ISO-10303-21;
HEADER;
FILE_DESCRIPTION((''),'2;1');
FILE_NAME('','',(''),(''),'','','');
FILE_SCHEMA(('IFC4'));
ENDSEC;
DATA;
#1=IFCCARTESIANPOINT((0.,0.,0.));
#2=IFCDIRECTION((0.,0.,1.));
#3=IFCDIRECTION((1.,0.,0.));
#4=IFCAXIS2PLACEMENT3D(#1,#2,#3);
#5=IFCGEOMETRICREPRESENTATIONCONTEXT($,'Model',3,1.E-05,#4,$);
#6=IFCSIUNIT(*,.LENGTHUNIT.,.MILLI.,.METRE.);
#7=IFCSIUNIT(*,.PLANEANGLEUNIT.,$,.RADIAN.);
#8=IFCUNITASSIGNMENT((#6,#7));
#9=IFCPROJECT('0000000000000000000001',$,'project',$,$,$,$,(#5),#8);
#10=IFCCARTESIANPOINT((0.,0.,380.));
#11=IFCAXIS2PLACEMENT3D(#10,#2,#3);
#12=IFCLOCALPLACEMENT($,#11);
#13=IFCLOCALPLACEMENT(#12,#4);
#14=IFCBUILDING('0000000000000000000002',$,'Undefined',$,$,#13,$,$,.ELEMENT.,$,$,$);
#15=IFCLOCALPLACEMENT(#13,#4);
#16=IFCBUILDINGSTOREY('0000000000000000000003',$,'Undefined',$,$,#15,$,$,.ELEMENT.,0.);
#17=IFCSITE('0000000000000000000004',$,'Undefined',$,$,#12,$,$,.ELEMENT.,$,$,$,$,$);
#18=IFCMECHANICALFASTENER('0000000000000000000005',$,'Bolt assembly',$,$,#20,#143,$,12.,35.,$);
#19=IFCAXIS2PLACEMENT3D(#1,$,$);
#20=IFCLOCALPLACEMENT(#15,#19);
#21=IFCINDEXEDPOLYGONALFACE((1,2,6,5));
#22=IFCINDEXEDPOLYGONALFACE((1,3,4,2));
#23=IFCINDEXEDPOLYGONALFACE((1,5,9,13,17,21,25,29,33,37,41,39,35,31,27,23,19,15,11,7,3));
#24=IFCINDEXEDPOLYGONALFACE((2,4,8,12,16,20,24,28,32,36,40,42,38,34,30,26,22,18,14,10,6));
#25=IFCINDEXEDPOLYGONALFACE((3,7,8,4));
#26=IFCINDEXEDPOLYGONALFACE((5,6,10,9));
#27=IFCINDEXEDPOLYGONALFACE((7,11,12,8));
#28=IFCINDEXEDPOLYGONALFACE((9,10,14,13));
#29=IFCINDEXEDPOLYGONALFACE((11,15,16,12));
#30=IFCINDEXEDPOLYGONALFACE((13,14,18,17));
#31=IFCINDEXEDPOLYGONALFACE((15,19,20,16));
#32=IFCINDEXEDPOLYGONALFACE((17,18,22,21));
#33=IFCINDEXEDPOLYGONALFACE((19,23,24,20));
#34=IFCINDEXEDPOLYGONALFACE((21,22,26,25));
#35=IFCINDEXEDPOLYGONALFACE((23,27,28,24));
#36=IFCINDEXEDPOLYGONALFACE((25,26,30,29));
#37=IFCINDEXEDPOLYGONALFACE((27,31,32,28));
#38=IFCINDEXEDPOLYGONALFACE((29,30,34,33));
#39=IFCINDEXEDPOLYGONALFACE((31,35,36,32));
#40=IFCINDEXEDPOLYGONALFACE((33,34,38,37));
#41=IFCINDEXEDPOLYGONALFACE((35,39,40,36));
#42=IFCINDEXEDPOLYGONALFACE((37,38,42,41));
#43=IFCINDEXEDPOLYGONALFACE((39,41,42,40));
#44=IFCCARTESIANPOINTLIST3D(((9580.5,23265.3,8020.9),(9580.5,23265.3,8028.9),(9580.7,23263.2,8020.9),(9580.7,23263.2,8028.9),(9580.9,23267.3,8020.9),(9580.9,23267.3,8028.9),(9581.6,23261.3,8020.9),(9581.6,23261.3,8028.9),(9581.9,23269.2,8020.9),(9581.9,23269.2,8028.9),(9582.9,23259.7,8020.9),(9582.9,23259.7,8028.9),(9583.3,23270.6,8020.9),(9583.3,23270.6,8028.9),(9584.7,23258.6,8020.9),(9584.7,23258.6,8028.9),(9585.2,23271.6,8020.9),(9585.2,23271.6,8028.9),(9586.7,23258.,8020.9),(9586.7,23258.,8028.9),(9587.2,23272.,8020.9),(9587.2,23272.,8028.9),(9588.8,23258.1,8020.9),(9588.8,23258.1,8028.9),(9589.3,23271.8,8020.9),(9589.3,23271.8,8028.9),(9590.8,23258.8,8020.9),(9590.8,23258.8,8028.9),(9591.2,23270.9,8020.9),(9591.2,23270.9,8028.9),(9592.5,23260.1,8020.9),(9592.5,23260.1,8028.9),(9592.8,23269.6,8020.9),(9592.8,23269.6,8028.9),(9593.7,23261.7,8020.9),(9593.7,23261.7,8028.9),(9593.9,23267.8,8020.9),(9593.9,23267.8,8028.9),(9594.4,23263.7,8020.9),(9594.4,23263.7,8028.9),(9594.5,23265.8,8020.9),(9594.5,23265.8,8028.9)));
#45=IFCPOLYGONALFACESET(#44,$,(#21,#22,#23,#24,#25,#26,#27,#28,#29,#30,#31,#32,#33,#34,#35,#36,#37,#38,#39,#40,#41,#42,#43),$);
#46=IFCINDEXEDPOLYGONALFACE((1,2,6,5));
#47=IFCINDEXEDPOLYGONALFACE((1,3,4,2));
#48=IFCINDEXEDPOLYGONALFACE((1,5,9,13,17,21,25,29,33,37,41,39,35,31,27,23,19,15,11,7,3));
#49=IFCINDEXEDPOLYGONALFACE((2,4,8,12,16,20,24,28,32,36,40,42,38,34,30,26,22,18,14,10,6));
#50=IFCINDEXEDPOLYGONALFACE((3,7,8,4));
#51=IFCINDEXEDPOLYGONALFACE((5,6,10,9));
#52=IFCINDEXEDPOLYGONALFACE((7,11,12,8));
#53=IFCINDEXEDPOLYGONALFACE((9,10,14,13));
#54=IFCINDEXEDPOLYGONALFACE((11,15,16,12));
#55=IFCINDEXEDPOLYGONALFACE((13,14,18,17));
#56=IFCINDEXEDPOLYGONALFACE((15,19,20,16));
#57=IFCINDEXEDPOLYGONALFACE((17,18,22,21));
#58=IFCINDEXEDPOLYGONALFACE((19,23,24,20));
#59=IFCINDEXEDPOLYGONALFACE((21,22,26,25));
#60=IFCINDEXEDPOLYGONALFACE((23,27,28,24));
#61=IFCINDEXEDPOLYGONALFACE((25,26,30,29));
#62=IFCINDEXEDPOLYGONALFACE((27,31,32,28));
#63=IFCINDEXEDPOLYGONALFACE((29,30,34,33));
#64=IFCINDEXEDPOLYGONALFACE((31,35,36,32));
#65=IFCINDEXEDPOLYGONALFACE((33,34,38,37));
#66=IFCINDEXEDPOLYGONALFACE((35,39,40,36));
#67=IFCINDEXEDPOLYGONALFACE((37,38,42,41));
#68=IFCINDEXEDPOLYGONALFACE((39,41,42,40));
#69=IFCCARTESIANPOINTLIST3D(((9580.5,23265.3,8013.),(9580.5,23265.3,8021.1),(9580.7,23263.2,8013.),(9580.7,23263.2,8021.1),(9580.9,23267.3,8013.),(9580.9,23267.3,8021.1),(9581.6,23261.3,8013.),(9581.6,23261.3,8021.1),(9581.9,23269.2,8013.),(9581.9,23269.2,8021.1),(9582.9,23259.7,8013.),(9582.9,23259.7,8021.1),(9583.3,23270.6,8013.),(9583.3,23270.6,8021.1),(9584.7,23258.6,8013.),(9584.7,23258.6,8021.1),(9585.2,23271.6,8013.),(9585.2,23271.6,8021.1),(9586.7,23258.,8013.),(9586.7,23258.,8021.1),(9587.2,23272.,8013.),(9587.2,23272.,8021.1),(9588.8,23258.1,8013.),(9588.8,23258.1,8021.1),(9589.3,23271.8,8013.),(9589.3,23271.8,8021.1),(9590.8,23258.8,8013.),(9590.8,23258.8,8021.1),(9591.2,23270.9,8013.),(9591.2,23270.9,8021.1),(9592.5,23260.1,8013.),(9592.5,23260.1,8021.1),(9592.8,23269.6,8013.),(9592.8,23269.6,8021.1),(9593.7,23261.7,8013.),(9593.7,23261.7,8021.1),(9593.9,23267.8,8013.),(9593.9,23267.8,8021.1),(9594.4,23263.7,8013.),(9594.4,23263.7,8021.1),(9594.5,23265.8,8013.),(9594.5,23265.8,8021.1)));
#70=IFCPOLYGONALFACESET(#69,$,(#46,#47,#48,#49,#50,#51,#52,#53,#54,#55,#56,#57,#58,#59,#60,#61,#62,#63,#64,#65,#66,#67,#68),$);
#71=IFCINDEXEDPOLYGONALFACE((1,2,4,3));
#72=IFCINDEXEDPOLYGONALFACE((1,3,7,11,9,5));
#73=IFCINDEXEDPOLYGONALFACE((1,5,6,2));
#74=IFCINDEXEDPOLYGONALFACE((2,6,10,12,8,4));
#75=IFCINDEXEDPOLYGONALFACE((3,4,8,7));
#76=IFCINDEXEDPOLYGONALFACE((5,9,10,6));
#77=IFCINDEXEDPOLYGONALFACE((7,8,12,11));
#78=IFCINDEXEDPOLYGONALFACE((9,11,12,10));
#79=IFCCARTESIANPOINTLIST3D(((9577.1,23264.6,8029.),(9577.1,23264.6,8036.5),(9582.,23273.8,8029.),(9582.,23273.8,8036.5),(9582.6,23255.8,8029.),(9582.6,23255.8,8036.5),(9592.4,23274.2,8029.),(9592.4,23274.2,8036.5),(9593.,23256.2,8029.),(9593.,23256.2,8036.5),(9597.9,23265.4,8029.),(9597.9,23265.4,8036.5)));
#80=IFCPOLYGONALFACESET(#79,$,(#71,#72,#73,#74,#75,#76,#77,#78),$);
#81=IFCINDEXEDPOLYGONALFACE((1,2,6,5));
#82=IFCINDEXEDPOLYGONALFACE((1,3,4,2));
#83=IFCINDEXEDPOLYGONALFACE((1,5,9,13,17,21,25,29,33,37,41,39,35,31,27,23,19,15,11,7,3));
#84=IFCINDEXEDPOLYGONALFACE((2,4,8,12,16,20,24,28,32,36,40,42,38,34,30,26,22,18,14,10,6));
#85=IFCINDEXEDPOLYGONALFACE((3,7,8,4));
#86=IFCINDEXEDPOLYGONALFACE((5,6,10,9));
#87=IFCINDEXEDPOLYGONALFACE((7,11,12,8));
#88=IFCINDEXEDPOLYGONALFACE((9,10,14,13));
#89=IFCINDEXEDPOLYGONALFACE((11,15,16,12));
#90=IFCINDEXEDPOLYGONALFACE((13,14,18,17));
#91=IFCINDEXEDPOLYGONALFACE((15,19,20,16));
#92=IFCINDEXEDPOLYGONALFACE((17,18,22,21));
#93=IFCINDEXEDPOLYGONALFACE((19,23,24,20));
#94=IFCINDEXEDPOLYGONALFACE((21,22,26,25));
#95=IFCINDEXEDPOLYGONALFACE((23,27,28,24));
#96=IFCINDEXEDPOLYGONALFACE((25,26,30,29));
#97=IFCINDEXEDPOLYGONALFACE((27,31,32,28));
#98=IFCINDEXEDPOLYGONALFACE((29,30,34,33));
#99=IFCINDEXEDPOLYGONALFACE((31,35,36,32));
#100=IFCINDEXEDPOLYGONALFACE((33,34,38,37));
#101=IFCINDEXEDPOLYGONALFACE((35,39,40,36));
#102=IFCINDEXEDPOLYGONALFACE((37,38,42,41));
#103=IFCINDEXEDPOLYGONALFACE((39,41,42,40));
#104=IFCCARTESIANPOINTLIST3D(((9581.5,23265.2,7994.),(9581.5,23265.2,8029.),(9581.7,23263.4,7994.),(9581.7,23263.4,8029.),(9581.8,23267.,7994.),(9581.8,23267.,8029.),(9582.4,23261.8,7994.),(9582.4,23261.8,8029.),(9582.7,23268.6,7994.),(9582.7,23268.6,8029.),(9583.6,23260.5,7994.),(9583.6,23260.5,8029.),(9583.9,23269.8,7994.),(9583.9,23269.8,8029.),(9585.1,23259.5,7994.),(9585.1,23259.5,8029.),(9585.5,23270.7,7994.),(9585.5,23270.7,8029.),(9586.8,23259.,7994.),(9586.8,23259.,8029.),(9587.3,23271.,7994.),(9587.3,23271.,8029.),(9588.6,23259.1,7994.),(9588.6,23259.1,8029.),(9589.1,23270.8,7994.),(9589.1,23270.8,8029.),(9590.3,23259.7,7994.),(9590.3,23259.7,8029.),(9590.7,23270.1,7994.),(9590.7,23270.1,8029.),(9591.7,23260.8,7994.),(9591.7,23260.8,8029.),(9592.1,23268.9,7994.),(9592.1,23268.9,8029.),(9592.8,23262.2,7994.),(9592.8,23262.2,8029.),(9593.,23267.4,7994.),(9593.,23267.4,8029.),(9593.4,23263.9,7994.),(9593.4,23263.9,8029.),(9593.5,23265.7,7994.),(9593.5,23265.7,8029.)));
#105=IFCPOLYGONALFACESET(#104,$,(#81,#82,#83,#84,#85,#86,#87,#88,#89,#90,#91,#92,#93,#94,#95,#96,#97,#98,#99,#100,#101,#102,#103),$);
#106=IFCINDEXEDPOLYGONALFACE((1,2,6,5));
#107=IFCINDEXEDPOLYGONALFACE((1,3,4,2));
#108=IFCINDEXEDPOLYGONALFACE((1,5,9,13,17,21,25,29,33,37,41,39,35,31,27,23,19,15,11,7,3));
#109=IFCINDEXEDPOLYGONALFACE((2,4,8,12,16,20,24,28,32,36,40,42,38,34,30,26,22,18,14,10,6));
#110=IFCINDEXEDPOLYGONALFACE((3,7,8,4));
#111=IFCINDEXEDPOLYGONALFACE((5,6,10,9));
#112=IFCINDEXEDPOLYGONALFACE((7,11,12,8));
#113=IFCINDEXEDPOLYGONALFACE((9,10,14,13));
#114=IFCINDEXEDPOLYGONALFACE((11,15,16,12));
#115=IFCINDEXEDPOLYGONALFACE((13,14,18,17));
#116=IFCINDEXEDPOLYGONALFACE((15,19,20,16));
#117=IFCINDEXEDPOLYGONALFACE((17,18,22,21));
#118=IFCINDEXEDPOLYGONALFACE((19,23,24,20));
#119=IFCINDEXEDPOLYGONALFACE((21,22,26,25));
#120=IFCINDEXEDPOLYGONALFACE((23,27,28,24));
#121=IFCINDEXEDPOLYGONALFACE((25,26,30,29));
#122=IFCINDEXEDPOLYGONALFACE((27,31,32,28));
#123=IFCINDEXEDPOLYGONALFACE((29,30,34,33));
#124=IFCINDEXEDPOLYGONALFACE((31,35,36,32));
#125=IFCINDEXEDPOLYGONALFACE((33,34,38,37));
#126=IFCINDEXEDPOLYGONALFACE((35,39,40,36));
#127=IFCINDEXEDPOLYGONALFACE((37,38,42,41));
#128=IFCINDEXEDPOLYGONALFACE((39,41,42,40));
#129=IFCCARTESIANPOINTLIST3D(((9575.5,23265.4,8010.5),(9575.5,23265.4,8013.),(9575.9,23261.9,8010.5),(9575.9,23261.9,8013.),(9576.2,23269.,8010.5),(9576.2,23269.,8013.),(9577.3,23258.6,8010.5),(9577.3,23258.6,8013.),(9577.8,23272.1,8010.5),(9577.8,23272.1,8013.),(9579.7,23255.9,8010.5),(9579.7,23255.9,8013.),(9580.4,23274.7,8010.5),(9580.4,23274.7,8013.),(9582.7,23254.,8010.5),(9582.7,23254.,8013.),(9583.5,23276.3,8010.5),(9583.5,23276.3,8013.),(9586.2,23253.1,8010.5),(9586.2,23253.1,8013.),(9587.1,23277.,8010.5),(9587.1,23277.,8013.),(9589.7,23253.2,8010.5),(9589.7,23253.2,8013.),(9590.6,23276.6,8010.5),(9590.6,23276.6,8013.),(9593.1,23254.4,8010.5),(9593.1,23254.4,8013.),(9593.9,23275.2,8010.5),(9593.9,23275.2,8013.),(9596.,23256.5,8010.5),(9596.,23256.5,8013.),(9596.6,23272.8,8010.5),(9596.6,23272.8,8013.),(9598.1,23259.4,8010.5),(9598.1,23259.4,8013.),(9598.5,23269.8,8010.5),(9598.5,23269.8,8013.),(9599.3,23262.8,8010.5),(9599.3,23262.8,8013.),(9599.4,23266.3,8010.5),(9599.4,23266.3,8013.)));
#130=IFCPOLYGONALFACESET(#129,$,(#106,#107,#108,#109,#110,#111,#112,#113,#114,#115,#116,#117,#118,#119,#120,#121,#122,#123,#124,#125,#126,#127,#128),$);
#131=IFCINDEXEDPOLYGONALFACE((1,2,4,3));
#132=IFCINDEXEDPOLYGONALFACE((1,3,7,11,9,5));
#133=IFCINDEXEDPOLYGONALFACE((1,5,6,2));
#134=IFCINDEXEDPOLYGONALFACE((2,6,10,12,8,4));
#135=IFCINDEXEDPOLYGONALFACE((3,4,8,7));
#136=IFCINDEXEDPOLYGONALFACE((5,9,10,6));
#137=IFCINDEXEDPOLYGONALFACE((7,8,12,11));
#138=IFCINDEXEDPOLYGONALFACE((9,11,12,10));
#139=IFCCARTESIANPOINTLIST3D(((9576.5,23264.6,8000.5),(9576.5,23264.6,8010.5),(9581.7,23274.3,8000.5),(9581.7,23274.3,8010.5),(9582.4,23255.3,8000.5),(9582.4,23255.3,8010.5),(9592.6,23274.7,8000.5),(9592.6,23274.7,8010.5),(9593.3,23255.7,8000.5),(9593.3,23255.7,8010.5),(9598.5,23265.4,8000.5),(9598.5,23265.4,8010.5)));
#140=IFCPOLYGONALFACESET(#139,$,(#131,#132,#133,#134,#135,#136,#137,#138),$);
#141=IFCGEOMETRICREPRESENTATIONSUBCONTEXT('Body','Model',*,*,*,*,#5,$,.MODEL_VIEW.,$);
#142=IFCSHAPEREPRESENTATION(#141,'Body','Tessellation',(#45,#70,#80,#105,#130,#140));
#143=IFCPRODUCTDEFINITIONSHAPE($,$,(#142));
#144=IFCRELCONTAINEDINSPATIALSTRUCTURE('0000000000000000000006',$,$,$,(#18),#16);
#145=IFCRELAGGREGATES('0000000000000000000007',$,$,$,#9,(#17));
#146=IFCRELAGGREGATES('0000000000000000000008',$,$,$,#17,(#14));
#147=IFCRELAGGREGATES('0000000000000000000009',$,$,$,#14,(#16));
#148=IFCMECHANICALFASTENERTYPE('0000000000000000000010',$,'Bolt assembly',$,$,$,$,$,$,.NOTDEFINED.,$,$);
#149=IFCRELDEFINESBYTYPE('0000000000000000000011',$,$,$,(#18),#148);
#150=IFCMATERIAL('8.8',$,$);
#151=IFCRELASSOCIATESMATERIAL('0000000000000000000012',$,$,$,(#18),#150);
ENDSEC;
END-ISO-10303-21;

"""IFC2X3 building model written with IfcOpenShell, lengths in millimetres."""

from ifc_helpers import new_model, si_unit, frame, origin_with_axes, origin_2d_with_axis, place, context, subcontext, project, spatial, polyline, circle, outline, extrude, source, transform, mapped, material, type_object, element, save


model = new_model("IFC2X3")

# Units and contexts
model_context = context("Model", 3, precision=1e-05, world=origin_with_axes())
body_context = subcontext(model_context, "Body", "Model", "MODEL_VIEW")
ifc_project = project(units=[si_unit("LENGTHUNIT", "METRE", prefix="MILLI"), si_unit("PLANEANGLEUNIT", "RADIAN")], contexts=[model_context])

# Site, building, storey
site_placement = place(None, frame((0.0, 0.0, 380.0), z_axis=(0.0, 0.0, 1.0), x_axis=(1.0, 0.0, 0.0)))
site = spatial("IfcSite", under=ifc_project, at=site_placement, Name="Undefined", CompositionType="ELEMENT")
building_placement = place(site_placement, origin_with_axes())
building = spatial("IfcBuilding", under=site, at=building_placement, Name="Undefined", CompositionType="ELEMENT")
storey_placement = place(building_placement, origin_with_axes())
storey = spatial("IfcBuildingStorey", under=building, at=storey_placement, Name="Undefined", CompositionType="ELEMENT", Elevation=0.0)

# Mechanical fastener
ifc_material_1 = material(Name="8.8")
mechanical_fastener_type = type_object("IfcMechanicalFastenerType", Name="Bolt assembly")
shared_shape_1 = source(origin_with_axes(), body_context, "Body", "SweptSolid", [
    extrude(circle(Radius=7.0, at=origin_2d_with_axis()), frame((0.0, -11.9, 0.0), z_axis=(0.0, 1.0, 0.0), x_axis=(1.0, 0.0, 0.0)), (0.0, 0.0, 1.0), 8.0),
    extrude(circle(Radius=7.0, at=origin_2d_with_axis()), frame((0.0, -4.1, 0.0), z_axis=(0.0, 1.0, 0.0), x_axis=(1.0, 0.0, 0.0)), (0.0, 0.0, 1.0), 8.1),
    extrude(outline(polyline([(9.0, -5.2), (9.0, 5.2), (0.0, 10.4), (-9.0, 5.2), (-9.0, -5.2), (0.0, -10.4), (9.0, -5.2)])), frame((0.0, -19.5, 0.0), z_axis=(0.0, 1.0, 0.0), x_axis=(1.0, 0.0, 0.0)), (0.0, 0.0, 1.0), 7.5),
    extrude(circle(Radius=6.0, at=origin_2d_with_axis()), frame((0.0, -12.0, 0.0), z_axis=(0.0, 1.0, 0.0), x_axis=(1.0, 0.0, 0.0)), (0.0, 0.0, 1.0), 35.0),
    extrude(circle(Radius=12.0, at=origin_2d_with_axis()), frame((0.0, 4.0, 0.0), z_axis=(0.0, 1.0, 0.0), x_axis=(1.0, 0.0, 0.0)), (0.0, 0.0, 1.0), 2.5),
    extrude(outline(polyline([(9.5, -5.5), (9.5, 5.5), (0.0, 11.0), (-9.5, 5.5), (-9.5, -5.5), (0.0, -11.0), (9.5, -5.5)])), frame((0.0, 6.5, 0.0), z_axis=(0.0, 1.0, 0.0), x_axis=(1.0, 0.0, 0.0)), (0.0, 0.0, 1.0), 10.0),
])
mechanical_fastener_1_placement = place(storey_placement, frame((9587.5, 23265.0, 8017.0), z_axis=(0.531995, -0.846748, 0.0), x_axis=(-0.846748, -0.531995, 0.0)))
element("IfcMechanicalFastener", 1, at=mechanical_fastener_1_placement, inside=storey, type_object=mechanical_fastener_type, material=ifc_material_1, Name="Bolt assembly", NominalDiameter=12.0, NominalLength=35.0, context=body_context, shape_type="MappedRepresentation", body=[
    mapped(shared_shape_1, transform((0.0, 0.0, 0.0))),
])

save(model, "model.ifc")
